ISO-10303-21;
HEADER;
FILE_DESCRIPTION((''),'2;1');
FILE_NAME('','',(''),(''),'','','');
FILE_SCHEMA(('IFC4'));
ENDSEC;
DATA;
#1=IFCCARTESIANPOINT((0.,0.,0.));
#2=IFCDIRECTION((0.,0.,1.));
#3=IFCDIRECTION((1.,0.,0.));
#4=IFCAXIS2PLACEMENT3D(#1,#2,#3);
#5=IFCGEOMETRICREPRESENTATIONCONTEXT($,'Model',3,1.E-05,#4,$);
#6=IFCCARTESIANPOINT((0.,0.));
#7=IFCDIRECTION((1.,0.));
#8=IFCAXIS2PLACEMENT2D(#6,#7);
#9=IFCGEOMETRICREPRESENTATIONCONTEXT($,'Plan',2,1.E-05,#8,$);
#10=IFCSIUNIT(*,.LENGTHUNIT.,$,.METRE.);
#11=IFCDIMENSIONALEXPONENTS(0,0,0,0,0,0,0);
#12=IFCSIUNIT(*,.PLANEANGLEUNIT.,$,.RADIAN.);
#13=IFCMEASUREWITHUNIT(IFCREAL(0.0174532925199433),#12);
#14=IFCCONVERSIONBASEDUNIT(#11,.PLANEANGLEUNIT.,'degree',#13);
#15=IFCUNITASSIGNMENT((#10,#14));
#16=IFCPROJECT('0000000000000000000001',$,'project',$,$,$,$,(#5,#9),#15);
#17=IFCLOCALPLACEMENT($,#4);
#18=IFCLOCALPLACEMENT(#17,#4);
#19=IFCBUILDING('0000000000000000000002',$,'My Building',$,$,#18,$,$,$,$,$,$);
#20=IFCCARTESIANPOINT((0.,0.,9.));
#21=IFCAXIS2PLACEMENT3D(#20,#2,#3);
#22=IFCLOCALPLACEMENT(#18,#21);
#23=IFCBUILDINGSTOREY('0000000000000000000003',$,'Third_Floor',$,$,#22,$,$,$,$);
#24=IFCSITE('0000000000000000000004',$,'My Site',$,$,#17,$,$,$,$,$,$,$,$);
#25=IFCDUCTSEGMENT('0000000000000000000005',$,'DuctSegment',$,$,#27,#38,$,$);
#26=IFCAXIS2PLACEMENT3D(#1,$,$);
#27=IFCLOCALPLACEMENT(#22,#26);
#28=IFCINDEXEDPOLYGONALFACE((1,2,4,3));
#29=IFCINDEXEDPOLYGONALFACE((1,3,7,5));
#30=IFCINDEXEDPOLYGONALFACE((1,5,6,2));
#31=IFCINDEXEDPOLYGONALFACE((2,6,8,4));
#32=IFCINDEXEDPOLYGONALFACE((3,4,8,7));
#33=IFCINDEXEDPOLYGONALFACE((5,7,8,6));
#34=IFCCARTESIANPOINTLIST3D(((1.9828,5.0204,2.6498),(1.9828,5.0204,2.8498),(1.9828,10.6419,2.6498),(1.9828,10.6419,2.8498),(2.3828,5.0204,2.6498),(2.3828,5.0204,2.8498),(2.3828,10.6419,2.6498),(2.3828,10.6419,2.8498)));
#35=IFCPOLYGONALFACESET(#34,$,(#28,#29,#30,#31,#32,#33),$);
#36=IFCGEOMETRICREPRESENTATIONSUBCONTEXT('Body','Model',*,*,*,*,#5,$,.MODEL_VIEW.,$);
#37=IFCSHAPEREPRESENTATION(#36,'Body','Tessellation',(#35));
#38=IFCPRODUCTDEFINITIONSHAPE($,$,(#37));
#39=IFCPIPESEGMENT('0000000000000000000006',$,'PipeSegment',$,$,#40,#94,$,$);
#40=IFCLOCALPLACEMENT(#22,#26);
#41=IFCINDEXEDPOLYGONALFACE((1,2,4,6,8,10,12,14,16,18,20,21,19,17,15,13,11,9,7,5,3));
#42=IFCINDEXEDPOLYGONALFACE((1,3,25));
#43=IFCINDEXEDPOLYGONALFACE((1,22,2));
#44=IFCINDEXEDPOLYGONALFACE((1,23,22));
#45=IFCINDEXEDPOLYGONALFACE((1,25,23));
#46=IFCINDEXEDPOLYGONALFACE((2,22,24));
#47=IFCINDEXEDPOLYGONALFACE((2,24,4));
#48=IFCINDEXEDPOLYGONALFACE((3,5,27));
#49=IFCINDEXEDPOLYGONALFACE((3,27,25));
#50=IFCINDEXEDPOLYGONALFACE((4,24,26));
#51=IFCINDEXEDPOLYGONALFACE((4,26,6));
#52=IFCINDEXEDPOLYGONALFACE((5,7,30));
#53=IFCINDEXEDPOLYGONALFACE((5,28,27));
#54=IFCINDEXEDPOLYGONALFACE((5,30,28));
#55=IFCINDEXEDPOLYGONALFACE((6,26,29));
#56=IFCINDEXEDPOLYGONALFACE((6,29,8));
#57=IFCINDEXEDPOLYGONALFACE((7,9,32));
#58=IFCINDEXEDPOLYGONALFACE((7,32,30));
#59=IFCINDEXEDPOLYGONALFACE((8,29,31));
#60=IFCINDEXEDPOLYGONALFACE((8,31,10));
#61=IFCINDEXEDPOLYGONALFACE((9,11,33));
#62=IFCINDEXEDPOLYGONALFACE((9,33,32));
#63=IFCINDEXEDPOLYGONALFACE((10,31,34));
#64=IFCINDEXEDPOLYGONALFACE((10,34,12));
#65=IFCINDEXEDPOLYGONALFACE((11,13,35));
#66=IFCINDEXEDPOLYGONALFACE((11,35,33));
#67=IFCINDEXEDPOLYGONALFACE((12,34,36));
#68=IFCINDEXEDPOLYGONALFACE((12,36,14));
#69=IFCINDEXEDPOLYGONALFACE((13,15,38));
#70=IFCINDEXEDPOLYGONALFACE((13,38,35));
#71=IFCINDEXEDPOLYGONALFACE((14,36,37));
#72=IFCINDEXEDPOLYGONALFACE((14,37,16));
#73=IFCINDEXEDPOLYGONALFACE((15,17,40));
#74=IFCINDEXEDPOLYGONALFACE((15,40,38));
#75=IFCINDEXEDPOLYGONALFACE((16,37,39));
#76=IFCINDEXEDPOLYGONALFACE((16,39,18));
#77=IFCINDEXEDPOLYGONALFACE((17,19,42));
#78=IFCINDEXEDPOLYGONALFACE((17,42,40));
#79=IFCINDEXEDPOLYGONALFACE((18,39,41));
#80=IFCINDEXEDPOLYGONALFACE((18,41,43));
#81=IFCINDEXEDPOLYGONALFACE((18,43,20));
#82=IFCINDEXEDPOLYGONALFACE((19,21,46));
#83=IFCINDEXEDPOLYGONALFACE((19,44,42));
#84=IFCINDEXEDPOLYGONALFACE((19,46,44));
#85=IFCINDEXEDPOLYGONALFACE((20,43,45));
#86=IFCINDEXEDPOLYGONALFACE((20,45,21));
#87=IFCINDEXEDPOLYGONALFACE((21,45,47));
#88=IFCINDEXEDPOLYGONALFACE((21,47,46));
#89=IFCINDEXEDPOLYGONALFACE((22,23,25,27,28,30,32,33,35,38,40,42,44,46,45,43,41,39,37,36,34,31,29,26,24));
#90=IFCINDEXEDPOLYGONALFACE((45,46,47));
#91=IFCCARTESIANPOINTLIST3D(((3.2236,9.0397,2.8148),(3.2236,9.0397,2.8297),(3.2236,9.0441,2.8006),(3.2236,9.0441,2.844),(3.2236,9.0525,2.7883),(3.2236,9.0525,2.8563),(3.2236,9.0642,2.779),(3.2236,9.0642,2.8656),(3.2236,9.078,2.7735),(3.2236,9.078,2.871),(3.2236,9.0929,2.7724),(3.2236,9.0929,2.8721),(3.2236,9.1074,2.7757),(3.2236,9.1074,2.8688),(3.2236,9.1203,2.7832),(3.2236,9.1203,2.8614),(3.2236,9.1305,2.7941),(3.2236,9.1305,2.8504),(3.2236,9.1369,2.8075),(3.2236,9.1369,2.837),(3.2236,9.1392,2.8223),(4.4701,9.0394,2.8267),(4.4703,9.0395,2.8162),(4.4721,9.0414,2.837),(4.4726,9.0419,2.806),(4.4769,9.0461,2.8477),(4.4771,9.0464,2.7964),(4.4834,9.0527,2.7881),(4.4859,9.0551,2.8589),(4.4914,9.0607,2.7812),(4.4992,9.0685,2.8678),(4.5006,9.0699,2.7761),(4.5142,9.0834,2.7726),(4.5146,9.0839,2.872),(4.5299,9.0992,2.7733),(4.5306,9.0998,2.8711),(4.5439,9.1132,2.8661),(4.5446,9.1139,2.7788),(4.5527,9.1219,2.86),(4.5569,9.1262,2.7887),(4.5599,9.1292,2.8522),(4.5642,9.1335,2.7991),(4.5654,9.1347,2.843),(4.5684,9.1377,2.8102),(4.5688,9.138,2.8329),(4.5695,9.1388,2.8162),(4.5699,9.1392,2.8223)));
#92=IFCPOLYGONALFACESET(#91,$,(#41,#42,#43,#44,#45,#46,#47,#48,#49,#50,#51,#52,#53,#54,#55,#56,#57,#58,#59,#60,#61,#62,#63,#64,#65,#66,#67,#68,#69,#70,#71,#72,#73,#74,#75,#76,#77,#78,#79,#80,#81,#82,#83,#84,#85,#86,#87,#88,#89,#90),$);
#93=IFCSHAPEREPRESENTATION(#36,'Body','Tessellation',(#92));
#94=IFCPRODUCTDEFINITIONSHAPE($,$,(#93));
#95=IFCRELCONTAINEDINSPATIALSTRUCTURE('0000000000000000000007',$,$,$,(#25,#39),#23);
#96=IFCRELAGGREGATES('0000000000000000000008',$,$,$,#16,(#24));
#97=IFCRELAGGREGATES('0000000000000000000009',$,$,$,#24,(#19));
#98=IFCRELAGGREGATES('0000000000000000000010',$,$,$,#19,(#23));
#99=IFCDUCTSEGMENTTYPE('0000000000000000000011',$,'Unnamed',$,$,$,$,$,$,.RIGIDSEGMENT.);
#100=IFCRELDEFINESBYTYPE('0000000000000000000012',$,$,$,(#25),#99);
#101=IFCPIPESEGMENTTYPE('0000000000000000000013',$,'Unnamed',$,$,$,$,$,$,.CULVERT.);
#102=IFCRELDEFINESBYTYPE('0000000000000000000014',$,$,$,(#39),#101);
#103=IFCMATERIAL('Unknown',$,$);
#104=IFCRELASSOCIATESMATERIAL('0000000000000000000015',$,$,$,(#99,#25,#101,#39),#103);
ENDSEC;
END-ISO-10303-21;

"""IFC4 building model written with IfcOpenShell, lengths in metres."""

from ifc_helpers import new_model, entity, si_unit, converted_unit, frame, origin_with_axes, origin_2d_with_axis, place, context, subcontext, project, spatial, rectangle, circle, extrude, clip, halfspace, material, material_profile, profile_set, profile_usage, type_object, element, save


model = new_model("IFC4")

# Units and contexts
model_context = context("Model", 3, precision=1e-05, world=origin_with_axes())
plan_context = context("Plan", 2, precision=1e-05, world=origin_2d_with_axis())
body_context_1 = subcontext(model_context, "Body", "Model", "MODEL_VIEW")
ifc_project = project(units=[si_unit("LENGTHUNIT", "METRE"), converted_unit("PLANEANGLEUNIT", "degree", entity("IfcReal", 0.0174532925199433), si_unit("PLANEANGLEUNIT", "RADIAN"), dimensions=[0, 0, 0, 0, 0, 0, 0])], contexts=[model_context, plan_context])

# Site, building, storey
site_placement = place(None, origin_with_axes())
site = spatial("IfcSite", under=ifc_project, at=site_placement, Name="My Site")
building_placement = place(site_placement, origin_with_axes())
building = spatial("IfcBuilding", under=site, at=building_placement, Name="My Building")
storey_placement = place(building_placement, frame((0.0, 0.0, 9.0), z_axis=(0.0, 0.0, 1.0), x_axis=(1.0, 0.0, 0.0)))
storey = spatial("IfcBuildingStorey", under=building, at=storey_placement, Name="Third_Floor")

# Shared definitions
ifc_material = material(Name="Unknown")

# Duct segment
ifc_material_profile_1 = material_profile(ifc_material, rectangle(XDim=0.4, YDim=0.2))
ifc_profile_set_1 = profile_set([ifc_material_profile_1])
duct_segment_type = type_object("IfcDuctSegmentType", Name="Unnamed", PredefinedType="RIGIDSEGMENT", material=ifc_profile_set_1)
ifc_profile_usage_1 = profile_usage(ifc_profile_set_1, cardinal=5)
duct_segment_1_placement = place(storey_placement, frame((2.1828, 10.6419, 2.7498), z_axis=(0.0, -1.0, 0.0), x_axis=(1.0, 0.0, 0.0)))
element("IfcDuctSegment", 1, at=duct_segment_1_placement, inside=storey, type_object=duct_segment_type, material=ifc_profile_usage_1, Name="DuctSegment", context=body_context_1, shape_type="SweptSolid", body=[
    extrude(rectangle(XDim=0.4, YDim=0.2), origin_with_axes(), (0.0, 0.0, 1.0), 5.6215),
])

# Pipe segment
ifc_material_profile_2 = material_profile(ifc_material, circle(Radius=0.05))
ifc_profile_set_2 = profile_set([ifc_material_profile_2])
pipe_segment_type = type_object("IfcPipeSegmentType", Name="Unnamed", PredefinedType="CULVERT", material=ifc_profile_set_2)
ifc_profile_usage_2 = profile_usage(ifc_profile_set_2, cardinal=5)
pipe_segment_1_placement = place(storey_placement, frame((3.2236, 9.0892, 2.8223), z_axis=(1.0, -0.000001, 0.000001), x_axis=(0.000001, 1.0, 0.0)))
element("IfcPipeSegment", 2, at=pipe_segment_1_placement, inside=storey, type_object=pipe_segment_type, material=ifc_profile_usage_2, Name="PipeSegment", context=body_context_1, shape_type="Clipping", body=[
    clip(extrude(circle(Radius=0.05), origin_with_axes(), (0.0, 0.0, 1.0), 1.3463), halfspace(frame((0.05, -3.0, 1.3463), z_axis=(-0.707106, -0.000001, 0.707107), x_axis=(-0.000001, 1.0, 0.0)), False)),
])

save(model, "model.ifc")
